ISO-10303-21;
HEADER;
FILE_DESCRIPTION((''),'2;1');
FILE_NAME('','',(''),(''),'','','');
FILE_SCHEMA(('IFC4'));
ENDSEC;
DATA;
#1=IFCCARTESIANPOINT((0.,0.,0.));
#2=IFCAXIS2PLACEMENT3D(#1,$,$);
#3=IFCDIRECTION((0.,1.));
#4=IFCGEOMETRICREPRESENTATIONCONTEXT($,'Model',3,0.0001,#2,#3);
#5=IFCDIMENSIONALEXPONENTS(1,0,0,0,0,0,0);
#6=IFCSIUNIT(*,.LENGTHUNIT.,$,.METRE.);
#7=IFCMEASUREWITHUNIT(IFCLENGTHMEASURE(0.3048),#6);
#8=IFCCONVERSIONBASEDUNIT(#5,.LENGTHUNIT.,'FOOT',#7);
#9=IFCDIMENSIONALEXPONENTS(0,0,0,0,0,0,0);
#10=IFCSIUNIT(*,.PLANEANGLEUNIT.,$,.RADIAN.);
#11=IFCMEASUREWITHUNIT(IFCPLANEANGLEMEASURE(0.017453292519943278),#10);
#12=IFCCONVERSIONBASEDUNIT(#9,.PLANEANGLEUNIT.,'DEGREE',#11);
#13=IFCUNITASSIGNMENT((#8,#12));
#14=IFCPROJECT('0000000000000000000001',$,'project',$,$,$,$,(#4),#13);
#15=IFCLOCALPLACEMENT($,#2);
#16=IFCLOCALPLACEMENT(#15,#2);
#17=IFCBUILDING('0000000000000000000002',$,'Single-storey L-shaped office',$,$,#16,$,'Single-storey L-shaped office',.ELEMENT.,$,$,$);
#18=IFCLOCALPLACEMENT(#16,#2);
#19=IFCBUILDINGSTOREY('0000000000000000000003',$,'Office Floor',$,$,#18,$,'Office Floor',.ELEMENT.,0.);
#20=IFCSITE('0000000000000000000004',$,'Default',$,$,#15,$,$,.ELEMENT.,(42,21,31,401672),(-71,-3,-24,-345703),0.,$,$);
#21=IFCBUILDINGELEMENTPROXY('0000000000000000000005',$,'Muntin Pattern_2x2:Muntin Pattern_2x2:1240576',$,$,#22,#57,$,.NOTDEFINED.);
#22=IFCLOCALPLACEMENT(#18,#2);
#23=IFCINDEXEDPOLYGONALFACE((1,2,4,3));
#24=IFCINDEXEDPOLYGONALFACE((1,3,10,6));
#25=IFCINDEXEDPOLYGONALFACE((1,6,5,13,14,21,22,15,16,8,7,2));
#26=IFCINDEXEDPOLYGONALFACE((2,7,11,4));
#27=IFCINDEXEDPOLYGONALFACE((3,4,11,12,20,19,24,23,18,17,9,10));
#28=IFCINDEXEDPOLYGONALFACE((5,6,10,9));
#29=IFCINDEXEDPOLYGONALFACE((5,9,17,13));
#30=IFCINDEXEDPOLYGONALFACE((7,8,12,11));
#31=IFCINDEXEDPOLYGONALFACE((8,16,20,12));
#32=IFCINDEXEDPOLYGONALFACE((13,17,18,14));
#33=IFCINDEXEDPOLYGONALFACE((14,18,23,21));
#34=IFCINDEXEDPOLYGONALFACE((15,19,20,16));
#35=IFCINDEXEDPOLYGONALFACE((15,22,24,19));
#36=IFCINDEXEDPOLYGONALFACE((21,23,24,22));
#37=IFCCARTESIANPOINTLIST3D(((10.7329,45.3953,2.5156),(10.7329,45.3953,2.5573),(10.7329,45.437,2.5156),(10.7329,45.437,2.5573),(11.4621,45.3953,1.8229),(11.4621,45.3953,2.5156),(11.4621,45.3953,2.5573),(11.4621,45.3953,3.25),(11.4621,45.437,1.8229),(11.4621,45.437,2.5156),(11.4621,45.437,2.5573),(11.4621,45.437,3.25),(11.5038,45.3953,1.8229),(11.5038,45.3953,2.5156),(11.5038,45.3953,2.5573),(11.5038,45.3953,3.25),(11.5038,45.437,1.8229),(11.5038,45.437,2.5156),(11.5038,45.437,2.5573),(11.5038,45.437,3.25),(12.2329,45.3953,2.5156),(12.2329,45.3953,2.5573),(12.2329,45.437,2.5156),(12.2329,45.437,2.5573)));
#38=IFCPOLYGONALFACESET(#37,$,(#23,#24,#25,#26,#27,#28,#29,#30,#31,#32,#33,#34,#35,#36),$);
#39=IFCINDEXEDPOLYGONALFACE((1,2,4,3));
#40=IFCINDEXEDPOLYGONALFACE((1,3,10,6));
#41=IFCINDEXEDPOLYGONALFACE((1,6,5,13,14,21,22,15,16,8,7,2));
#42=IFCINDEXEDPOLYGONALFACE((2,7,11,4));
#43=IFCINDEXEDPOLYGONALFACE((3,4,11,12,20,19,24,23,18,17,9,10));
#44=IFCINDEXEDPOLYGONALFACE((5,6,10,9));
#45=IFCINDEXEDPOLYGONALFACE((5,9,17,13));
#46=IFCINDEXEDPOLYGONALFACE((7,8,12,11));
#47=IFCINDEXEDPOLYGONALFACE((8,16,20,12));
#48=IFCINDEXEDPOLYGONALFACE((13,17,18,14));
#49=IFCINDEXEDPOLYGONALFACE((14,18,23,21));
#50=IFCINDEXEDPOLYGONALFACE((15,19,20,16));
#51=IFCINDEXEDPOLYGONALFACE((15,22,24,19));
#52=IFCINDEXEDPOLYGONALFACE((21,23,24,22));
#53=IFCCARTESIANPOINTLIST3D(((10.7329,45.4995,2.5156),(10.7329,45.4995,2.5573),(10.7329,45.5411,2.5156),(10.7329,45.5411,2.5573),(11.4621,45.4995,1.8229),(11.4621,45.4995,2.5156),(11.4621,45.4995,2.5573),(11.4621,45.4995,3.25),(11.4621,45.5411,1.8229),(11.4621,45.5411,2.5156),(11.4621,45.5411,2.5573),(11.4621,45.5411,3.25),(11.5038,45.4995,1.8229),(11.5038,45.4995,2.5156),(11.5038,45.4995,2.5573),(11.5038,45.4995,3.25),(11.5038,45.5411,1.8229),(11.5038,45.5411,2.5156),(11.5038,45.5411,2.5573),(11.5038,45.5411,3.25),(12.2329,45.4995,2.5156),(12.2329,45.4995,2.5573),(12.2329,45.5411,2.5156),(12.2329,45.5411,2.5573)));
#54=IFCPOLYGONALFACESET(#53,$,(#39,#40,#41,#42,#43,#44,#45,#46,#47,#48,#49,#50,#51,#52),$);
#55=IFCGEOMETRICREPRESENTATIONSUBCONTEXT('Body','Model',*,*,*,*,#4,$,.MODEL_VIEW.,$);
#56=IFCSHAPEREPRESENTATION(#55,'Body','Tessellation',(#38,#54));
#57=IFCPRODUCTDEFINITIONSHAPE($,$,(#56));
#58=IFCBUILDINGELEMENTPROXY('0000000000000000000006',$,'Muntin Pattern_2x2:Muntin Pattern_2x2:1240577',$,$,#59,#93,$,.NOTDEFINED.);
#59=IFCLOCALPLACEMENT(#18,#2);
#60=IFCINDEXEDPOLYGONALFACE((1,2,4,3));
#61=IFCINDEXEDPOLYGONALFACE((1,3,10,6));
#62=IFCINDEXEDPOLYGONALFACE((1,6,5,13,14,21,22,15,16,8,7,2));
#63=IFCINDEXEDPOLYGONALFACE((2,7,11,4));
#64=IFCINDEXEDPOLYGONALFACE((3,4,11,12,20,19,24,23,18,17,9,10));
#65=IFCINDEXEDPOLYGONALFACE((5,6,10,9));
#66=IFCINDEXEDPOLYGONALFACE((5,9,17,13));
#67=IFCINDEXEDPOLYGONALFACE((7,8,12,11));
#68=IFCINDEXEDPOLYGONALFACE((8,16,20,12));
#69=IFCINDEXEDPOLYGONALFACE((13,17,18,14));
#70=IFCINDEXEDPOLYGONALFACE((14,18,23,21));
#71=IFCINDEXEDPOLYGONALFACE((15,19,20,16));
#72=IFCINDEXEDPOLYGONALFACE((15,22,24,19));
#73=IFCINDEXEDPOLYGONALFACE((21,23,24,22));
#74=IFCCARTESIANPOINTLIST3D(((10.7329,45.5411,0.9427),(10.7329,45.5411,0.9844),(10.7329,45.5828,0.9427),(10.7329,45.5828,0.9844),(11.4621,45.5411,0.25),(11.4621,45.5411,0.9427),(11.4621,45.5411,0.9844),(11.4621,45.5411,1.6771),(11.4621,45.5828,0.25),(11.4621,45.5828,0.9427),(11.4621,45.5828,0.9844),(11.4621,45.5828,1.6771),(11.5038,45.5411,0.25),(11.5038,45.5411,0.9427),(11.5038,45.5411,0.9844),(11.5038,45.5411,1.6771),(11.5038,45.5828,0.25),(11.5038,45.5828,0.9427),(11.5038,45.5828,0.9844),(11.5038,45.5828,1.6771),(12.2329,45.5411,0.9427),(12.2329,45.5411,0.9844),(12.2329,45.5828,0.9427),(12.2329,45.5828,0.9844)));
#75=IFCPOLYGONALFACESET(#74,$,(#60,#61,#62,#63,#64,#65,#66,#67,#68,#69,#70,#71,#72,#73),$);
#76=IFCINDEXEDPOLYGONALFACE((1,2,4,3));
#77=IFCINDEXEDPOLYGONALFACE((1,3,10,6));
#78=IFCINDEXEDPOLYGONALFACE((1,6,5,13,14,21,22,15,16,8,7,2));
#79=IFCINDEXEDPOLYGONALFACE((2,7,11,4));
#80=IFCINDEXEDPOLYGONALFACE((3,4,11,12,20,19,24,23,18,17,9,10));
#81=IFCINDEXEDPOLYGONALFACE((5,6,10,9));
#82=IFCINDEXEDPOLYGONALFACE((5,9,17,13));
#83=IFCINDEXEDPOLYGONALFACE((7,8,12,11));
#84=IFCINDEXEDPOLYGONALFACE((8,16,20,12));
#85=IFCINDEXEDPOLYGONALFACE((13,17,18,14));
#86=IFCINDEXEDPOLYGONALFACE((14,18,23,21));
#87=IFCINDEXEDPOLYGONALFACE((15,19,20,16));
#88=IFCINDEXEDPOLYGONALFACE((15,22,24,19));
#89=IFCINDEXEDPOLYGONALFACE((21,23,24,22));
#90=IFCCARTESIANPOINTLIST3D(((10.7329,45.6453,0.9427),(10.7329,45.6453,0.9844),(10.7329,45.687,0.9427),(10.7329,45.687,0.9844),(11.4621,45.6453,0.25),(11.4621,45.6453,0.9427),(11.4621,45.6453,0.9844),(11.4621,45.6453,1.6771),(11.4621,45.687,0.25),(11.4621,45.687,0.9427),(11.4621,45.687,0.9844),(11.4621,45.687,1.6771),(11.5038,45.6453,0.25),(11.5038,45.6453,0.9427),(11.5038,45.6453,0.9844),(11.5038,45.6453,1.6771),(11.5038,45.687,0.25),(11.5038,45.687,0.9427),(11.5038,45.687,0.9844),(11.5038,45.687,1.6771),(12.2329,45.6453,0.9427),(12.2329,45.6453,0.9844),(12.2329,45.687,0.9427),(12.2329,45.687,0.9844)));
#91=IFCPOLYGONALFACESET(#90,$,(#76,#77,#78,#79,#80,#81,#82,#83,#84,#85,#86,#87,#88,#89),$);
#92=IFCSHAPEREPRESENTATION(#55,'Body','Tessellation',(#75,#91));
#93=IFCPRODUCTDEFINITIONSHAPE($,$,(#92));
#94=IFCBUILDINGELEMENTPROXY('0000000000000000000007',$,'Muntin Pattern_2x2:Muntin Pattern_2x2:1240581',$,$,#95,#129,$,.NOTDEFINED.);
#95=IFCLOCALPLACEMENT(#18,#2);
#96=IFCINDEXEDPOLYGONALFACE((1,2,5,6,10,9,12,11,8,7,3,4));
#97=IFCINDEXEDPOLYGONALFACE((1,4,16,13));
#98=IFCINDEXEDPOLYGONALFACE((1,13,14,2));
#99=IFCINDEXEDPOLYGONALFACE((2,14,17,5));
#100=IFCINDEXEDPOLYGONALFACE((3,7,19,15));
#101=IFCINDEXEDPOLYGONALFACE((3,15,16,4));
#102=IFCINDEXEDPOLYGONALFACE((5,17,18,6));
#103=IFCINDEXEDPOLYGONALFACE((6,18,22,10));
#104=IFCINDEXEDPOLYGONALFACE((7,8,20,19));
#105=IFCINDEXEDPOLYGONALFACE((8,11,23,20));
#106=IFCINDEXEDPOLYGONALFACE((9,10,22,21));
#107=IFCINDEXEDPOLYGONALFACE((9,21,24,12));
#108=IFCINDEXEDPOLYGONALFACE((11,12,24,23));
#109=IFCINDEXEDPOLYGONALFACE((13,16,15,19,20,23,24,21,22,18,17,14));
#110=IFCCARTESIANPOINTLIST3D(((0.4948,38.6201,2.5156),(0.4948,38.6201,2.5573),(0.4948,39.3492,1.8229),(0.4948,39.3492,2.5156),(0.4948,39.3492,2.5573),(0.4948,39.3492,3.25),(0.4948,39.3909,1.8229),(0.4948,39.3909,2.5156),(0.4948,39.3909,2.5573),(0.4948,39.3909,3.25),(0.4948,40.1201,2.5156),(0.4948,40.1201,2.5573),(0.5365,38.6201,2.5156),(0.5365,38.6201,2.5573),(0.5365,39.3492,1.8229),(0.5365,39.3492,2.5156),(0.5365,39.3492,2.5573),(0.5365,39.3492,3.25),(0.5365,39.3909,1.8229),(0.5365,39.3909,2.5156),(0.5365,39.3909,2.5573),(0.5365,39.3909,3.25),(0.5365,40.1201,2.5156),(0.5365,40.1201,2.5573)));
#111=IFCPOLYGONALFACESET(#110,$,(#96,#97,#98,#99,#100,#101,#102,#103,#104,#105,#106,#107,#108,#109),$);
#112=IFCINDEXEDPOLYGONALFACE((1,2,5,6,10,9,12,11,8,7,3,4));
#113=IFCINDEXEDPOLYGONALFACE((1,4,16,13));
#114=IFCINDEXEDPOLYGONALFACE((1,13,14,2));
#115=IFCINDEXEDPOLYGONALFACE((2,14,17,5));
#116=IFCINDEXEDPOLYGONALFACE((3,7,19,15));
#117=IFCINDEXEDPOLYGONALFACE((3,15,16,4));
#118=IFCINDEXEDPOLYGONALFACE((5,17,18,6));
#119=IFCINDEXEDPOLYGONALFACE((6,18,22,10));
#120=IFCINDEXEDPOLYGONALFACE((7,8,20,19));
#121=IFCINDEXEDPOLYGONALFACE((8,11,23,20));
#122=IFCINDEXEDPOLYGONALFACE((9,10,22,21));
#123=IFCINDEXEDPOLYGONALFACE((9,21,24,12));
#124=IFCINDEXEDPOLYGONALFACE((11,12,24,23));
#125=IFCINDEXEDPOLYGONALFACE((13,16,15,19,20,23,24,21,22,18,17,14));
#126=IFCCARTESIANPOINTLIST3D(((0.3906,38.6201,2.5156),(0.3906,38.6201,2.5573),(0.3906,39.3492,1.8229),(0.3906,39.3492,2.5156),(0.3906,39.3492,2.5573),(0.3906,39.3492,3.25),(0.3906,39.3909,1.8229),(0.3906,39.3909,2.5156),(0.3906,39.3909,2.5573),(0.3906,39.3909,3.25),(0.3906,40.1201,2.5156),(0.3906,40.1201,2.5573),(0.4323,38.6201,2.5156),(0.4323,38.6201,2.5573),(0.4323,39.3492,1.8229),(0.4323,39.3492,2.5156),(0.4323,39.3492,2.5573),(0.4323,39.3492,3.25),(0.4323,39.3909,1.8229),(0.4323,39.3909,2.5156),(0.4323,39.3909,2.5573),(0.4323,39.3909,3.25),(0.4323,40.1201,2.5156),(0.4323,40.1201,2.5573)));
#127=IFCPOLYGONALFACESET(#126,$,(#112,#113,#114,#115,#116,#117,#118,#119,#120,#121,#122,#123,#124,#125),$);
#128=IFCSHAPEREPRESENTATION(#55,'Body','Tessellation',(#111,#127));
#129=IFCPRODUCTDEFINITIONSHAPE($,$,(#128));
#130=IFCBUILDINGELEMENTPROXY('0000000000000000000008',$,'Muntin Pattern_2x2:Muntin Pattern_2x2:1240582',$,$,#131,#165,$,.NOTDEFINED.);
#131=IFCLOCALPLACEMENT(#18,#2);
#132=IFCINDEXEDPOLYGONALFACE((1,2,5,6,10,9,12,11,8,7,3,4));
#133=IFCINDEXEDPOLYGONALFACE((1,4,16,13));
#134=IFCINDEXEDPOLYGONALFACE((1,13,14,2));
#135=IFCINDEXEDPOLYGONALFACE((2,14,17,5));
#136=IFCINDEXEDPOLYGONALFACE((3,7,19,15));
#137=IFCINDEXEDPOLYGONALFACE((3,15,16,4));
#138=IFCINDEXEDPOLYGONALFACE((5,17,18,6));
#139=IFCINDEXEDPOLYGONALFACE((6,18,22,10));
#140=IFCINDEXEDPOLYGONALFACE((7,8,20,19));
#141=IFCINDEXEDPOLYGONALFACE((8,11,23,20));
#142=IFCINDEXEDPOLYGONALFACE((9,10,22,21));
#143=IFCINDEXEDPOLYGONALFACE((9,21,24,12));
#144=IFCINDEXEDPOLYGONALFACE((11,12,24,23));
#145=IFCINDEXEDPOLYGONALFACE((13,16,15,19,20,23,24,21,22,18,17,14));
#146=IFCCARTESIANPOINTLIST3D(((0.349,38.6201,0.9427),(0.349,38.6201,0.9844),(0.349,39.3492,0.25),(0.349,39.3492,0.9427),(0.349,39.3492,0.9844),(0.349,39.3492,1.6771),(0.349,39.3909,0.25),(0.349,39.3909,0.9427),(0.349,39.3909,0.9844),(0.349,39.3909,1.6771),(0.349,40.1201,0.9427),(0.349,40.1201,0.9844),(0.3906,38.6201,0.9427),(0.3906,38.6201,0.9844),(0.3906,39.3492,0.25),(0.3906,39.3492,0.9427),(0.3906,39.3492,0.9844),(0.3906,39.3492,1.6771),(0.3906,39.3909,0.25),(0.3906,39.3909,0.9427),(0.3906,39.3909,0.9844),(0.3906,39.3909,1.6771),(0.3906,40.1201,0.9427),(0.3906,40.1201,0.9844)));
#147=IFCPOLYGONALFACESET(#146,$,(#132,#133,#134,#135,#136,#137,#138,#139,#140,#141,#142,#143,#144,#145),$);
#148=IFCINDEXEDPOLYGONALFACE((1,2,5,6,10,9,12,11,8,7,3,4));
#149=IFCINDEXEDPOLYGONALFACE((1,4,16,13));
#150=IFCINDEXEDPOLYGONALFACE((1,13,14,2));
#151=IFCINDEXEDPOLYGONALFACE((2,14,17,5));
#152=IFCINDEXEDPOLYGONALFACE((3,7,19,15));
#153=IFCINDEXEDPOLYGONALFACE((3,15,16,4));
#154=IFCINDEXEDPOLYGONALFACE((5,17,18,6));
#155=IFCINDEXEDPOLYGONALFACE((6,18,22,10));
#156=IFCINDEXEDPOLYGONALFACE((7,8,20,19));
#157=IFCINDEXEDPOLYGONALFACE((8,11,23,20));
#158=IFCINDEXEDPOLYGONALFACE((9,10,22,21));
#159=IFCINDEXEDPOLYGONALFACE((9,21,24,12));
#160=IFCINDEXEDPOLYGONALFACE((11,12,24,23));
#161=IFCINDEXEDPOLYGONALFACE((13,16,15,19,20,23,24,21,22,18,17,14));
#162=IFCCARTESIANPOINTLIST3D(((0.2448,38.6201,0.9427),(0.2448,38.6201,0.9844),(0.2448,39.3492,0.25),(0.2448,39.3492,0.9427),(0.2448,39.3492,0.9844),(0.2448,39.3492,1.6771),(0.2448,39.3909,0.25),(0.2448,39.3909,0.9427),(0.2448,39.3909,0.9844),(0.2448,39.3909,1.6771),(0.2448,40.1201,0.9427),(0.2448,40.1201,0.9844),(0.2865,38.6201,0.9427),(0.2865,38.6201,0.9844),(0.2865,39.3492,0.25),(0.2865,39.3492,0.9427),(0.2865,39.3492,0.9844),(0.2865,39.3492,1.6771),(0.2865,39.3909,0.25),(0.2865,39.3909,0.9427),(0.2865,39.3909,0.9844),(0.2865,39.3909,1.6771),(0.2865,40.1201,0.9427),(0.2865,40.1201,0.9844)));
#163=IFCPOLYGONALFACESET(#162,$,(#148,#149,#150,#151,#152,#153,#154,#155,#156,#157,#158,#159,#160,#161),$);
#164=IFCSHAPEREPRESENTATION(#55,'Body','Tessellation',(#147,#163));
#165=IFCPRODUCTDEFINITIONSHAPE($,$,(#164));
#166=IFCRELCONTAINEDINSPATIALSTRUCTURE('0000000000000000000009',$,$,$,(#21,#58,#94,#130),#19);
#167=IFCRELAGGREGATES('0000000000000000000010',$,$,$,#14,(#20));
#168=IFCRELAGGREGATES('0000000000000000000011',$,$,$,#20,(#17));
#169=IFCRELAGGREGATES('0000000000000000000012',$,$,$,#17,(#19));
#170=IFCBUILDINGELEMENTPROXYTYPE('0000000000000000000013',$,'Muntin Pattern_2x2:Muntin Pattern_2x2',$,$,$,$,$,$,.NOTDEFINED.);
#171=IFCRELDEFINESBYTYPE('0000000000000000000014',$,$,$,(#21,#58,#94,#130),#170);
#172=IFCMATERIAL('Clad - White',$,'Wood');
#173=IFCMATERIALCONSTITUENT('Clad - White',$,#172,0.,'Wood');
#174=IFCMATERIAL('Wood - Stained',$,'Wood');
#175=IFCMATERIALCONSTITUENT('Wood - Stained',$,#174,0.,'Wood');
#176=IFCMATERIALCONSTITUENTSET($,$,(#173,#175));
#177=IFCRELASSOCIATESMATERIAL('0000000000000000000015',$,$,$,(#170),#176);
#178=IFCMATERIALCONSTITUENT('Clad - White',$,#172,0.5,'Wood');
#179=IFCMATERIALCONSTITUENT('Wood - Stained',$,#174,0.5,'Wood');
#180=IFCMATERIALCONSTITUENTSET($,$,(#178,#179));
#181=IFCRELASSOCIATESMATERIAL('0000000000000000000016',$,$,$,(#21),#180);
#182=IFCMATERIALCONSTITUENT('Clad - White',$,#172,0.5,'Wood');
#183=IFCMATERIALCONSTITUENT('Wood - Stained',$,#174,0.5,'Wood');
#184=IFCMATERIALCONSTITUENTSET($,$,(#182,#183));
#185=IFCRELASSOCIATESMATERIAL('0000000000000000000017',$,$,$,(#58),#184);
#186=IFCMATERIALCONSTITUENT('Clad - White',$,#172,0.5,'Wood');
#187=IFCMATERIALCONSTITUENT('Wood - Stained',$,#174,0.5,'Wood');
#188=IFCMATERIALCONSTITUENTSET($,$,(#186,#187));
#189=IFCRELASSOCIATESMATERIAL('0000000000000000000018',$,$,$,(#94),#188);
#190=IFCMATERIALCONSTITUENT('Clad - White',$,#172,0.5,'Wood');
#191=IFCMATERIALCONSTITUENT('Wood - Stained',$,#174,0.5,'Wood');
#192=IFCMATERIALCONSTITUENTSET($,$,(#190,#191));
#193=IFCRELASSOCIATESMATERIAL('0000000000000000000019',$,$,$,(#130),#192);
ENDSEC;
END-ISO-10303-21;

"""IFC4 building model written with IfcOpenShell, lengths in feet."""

from ifc_helpers import new_model, entity, si_unit, converted_unit, direction, frame, origin, place, context, subcontext, project, spatial, indexed_curve, outline, extrude, source, transform, mapped, material, constituent, constituent_set, type_object, type_shapes, element, save


model = new_model("IFC4")

# Units and contexts
model_context = context("Model", 3, precision=0.0001, world=origin(), true_north=direction((0.0, 1.0)))
body_context = subcontext(model_context, "Body", "Model", "MODEL_VIEW")
ifc_project = project(units=[converted_unit("LENGTHUNIT", "FOOT", entity("IfcLengthMeasure", 0.3048), si_unit("LENGTHUNIT", "METRE"), dimensions=[1, 0, 0, 0, 0, 0, 0]), converted_unit("PLANEANGLEUNIT", "DEGREE", entity("IfcPlaneAngleMeasure", 0.017453292519943278), si_unit("PLANEANGLEUNIT", "RADIAN"), dimensions=[0, 0, 0, 0, 0, 0, 0])], contexts=[model_context])

# Site, building, storey
site_placement = place(None, origin())
site = spatial("IfcSite", under=ifc_project, at=site_placement, Name="Default", CompositionType="ELEMENT", RefLatitude=(42, 21, 31, 401672), RefLongitude=(-71, -3, -24, -345703), RefElevation=0.0)
building_placement = place(site_placement, origin())
building = spatial("IfcBuilding", under=site, at=building_placement, Name="Single-storey L-shaped office", LongName="Single-storey L-shaped office", CompositionType="ELEMENT")
storey_placement = place(building_placement, origin())
storey = spatial("IfcBuildingStorey", under=building, at=storey_placement, Name="Office Floor", LongName="Office Floor", CompositionType="ELEMENT", Elevation=0.0)

# Shared definitions
ifc_material_1 = material(Name="Wood - Stained", Category="Wood")

# Building element proxies
ifc_material_2 = material(Name="Clad - White", Category="Wood")
ifc_constituent_1 = constituent(ifc_material_2, Name="Clad - White", Category="Wood", fraction=0.0)
ifc_constituent_2 = constituent(ifc_material_1, Name="Wood - Stained", Category="Wood", fraction=0.0)
ifc_constituent_set_1 = constituent_set(constituents=[ifc_constituent_1, ifc_constituent_2])
building_element_proxy_type_1 = type_object("IfcBuildingElementProxyType", Name="Muntin Pattern_2x2:Muntin Pattern_2x2", PredefinedType="NOTDEFINED", material=ifc_constituent_set_1)
shared_shape_1 = source(origin(), body_context, "Body", "SweptSolid", [
    extrude(outline(indexed_curve([(0.0208, -0.0208), (0.7135, -0.0208), (0.7135, 0.0208), (0.0208, 0.0208), (0.0208, 0.75), (-0.0208, 0.75), (-0.0208, 0.0208), (-0.7135, 0.0208), (-0.7135, -0.0208), (-0.0208, -0.0208), (-0.0208, -0.75), (0.0208, -0.75), (0.0208, -0.0208)], self_intersect=False)), frame((0.0, 0.0312, 0.7135), z_axis=(0.0, 1.0, 0.0), x_axis=(0.0, 0.0, 1.0)), (0.0, 0.0, 1.0), 0.0417),
    extrude(outline(indexed_curve([(0.0208, -0.0208), (0.7135, -0.0208), (0.7135, 0.0208), (0.0208, 0.0208), (0.0208, 0.75), (-0.0208, 0.75), (-0.0208, 0.0208), (-0.7135, 0.0208), (-0.7135, -0.0208), (-0.0208, -0.0208), (-0.0208, -0.75), (0.0208, -0.75), (0.0208, -0.0208)], self_intersect=False)), frame((0.0, -0.0729, 0.7135), z_axis=(0.0, 1.0, 0.0), x_axis=(0.0, 0.0, 1.0)), (0.0, 0.0, 1.0), 0.0417),
])
type_shapes(building_element_proxy_type_1, [shared_shape_1])
ifc_constituent_3 = constituent(ifc_material_2, Name="Clad - White", Category="Wood", fraction=0.5)
ifc_constituent_4 = constituent(ifc_material_1, Name="Wood - Stained", Category="Wood", fraction=0.5)
ifc_constituent_set_2 = constituent_set(constituents=[ifc_constituent_3, ifc_constituent_4])
proxy_1_placement = place(storey_placement, frame((11.4829, 45.4682, 1.8229), z_axis=(0.0, 0.0, 1.0), x_axis=(-1.0, 0.0, 0.0)))
element("IfcBuildingElementProxy", 1, at=proxy_1_placement, inside=storey, type_object=building_element_proxy_type_1, material=ifc_constituent_set_2, Name="Muntin Pattern_2x2:Muntin Pattern_2x2:1240576", PredefinedType="NOTDEFINED", context=body_context, shape_type="MappedRepresentation", body=[
    mapped(shared_shape_1, transform((0.0, 0.0, 0.0), scale=1.0)),
])
ifc_constituent_5 = constituent(ifc_material_2, Name="Clad - White", Category="Wood", fraction=0.5)
ifc_constituent_6 = constituent(ifc_material_1, Name="Wood - Stained", Category="Wood", fraction=0.5)
ifc_constituent_set_3 = constituent_set(constituents=[ifc_constituent_5, ifc_constituent_6])
proxy_2_placement = place(storey_placement, frame((11.4829, 45.6141, 0.25), z_axis=(0.0, 0.0, 1.0), x_axis=(-1.0, 0.0, 0.0)))
element("IfcBuildingElementProxy", 2, at=proxy_2_placement, inside=storey, type_object=building_element_proxy_type_1, material=ifc_constituent_set_3, Name="Muntin Pattern_2x2:Muntin Pattern_2x2:1240577", PredefinedType="NOTDEFINED", context=body_context, shape_type="MappedRepresentation", body=[
    mapped(shared_shape_1, transform((0.0, 0.0, 0.0), scale=1.0)),
])
ifc_constituent_7 = constituent(ifc_material_2, Name="Clad - White", Category="Wood", fraction=0.5)
ifc_constituent_8 = constituent(ifc_material_1, Name="Wood - Stained", Category="Wood", fraction=0.5)
ifc_constituent_set_4 = constituent_set(constituents=[ifc_constituent_7, ifc_constituent_8])
proxy_3_placement = place(storey_placement, frame((0.4635, 39.3701, 1.8229), z_axis=(0.0, 0.0, 1.0), x_axis=(0.0, -1.0, 0.0)))
element("IfcBuildingElementProxy", 3, at=proxy_3_placement, inside=storey, type_object=building_element_proxy_type_1, material=ifc_constituent_set_4, Name="Muntin Pattern_2x2:Muntin Pattern_2x2:1240581", PredefinedType="NOTDEFINED", context=body_context, shape_type="MappedRepresentation", body=[
    mapped(shared_shape_1, transform((0.0, 0.0, 0.0), scale=1.0)),
])
ifc_constituent_9 = constituent(ifc_material_2, Name="Clad - White", Category="Wood", fraction=0.5)
ifc_constituent_10 = constituent(ifc_material_1, Name="Wood - Stained", Category="Wood", fraction=0.5)
ifc_constituent_set_5 = constituent_set(constituents=[ifc_constituent_9, ifc_constituent_10])
proxy_4_placement = place(storey_placement, frame((0.3177, 39.3701, 0.25), z_axis=(0.0, 0.0, 1.0), x_axis=(0.0, -1.0, 0.0)))
element("IfcBuildingElementProxy", 4, at=proxy_4_placement, inside=storey, type_object=building_element_proxy_type_1, material=ifc_constituent_set_5, Name="Muntin Pattern_2x2:Muntin Pattern_2x2:1240582", PredefinedType="NOTDEFINED", context=body_context, shape_type="MappedRepresentation", body=[
    mapped(shared_shape_1, transform((0.0, 0.0, 0.0), scale=1.0)),
])

save(model, "model.ifc")
